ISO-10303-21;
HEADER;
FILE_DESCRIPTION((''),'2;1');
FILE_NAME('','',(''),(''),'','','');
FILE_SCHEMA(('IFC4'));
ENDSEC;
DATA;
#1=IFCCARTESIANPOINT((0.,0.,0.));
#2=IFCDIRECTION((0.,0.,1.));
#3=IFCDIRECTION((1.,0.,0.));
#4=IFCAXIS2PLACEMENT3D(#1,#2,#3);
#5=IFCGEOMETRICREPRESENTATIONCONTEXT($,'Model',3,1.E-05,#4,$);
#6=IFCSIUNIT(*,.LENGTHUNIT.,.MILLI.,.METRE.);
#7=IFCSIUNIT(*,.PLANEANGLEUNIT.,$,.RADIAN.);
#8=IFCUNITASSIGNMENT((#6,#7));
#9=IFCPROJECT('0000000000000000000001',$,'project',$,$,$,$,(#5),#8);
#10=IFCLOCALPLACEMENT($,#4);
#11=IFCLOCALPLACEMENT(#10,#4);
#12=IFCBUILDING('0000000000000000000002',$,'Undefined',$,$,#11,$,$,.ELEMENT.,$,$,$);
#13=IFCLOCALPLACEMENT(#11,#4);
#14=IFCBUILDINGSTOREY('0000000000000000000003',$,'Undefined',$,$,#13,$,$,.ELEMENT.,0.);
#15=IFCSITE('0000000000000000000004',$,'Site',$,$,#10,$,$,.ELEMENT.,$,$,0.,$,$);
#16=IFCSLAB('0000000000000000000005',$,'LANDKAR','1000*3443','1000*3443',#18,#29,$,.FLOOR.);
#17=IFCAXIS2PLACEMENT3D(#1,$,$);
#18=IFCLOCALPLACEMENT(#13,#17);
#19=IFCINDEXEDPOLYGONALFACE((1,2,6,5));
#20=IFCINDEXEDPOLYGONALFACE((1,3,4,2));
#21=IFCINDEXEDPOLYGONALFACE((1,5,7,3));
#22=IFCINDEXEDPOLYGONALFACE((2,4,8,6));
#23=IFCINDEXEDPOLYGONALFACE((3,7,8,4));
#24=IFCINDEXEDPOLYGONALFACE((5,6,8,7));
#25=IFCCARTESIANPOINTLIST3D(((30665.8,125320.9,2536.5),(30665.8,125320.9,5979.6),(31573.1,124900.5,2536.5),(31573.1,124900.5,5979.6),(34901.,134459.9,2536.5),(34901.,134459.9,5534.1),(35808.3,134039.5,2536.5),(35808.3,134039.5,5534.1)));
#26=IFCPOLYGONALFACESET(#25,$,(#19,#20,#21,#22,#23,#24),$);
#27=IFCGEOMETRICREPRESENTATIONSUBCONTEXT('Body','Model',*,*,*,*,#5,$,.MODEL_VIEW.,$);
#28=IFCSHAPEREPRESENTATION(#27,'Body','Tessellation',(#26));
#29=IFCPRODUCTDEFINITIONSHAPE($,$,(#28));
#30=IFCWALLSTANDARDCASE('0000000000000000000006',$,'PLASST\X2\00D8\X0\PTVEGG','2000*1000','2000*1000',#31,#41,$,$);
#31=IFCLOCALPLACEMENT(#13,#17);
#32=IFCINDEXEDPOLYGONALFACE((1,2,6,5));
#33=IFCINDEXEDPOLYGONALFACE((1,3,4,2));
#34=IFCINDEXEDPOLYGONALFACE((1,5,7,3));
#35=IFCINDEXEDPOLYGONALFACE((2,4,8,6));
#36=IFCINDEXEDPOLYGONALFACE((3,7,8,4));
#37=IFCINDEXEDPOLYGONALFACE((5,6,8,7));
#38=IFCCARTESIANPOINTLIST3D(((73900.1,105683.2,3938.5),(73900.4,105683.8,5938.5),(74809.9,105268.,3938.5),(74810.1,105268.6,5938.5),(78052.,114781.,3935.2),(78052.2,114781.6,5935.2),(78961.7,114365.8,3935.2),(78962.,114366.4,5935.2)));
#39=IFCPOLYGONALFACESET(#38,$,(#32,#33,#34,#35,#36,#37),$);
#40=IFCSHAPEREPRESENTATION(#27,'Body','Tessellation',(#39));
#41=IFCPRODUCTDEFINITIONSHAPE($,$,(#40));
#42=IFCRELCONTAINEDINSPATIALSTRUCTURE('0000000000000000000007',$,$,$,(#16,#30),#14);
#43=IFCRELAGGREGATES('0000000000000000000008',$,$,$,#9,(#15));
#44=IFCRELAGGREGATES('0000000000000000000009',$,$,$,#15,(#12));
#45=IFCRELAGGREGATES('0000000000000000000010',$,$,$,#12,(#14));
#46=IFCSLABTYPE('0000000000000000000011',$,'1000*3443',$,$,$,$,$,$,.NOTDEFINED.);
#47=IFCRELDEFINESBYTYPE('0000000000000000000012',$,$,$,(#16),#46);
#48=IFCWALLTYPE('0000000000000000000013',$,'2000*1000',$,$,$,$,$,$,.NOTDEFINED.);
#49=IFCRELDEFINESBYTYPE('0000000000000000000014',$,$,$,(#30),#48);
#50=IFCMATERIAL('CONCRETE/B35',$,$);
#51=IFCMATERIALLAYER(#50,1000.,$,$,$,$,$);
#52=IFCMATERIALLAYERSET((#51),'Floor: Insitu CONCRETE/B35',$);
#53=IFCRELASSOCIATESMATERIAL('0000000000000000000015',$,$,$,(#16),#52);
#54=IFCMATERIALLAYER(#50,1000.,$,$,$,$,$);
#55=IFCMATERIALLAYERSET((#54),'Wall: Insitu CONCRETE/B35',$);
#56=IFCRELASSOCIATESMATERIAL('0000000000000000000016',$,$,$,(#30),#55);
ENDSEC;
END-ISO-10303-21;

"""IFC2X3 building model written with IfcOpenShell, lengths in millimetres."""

from ifc_helpers import new_model, si_unit, frame, frame_2d, origin_with_axes, place, context, subcontext, project, spatial, polyline, rectangle, outline, extrude, material, layer, layer_set, layer_usage, type_object, element, save


model = new_model("IFC2X3")

# Units and contexts
model_context = context("Model", 3, precision=1e-05, world=origin_with_axes())
body_context = subcontext(model_context, "Body", "Model", "MODEL_VIEW")
ifc_project = project(units=[si_unit("LENGTHUNIT", "METRE", prefix="MILLI"), si_unit("PLANEANGLEUNIT", "RADIAN")], contexts=[model_context])

# Site, building, storey
site_placement = place(None, origin_with_axes())
site = spatial("IfcSite", under=ifc_project, at=site_placement, Name="Site", CompositionType="ELEMENT", RefElevation=0.0)
building_placement = place(site_placement, origin_with_axes())
building = spatial("IfcBuilding", under=site, at=building_placement, Name="Undefined", CompositionType="ELEMENT")
storey_placement = place(building_placement, origin_with_axes())
storey = spatial("IfcBuildingStorey", under=building, at=storey_placement, Name="Undefined", CompositionType="ELEMENT", Elevation=0.0)

# Shared definitions
ifc_material_1 = material(Name="CONCRETE/B35")

# Slab
ifc_layer_1 = layer(ifc_material_1, 1000.0)
ifc_layer_set_1 = layer_set([ifc_layer_1], Name="Floor: Insitu CONCRETE/B35")
ifc_layer_usage_1 = layer_usage(ifc_layer_set_1, "AXIS3", "POSITIVE", -500.0)
slab_type_1 = type_object("IfcSlabType", Name="1000*3443", PredefinedType="NOTDEFINED")
slab_1_placement = place(storey_placement, frame((31119.5, 125110.7, 2536.5), z_axis=(0.907309, -0.420464, 0.0), x_axis=(0.420464, 0.907309, 0.000004)))
element("IfcSlab", 1, at=slab_1_placement, inside=storey, type_object=slab_type_1, material=ifc_layer_usage_1, Name="LANDKAR", Description="1000*3443", ObjectType="1000*3443", PredefinedType="FLOOR", context=body_context, shape_type="SweptSolid", body=[
    extrude(outline(polyline([(0.0, 0.0), (10072.7, 0.0), (10072.7, 2997.6), (0.0, 3443.1), (0.0, 0.0)])), frame((0.0, 0.0, -500.0), z_axis=(0.0, 0.0, 1.0), x_axis=(1.0, 0.0, 0.0)), (0.0, 0.0, 1.0), 1000.0),
])

# Wall
ifc_layer_2 = layer(ifc_material_1, 1000.0)
ifc_layer_set_2 = layer_set([ifc_layer_2], Name="Wall: Insitu CONCRETE/B35")
ifc_layer_usage_2 = layer_usage(ifc_layer_set_2, "AXIS2", "POSITIVE", -500.0)
wall_type = type_object("IfcWallType", Name="2000*1000", PredefinedType="NOTDEFINED")
wall_placement = place(storey_placement, frame((78506.8, 114573.4, 3935.2), z_axis=(0.000135, 0.000296, 1.0), x_axis=(-0.41517, -0.909744, 0.000326)))
element("IfcWallStandardCase", 2, at=wall_placement, inside=storey, type_object=wall_type, material=ifc_layer_usage_2, Name="PLASSTØPTVEGG", Description="2000*1000", ObjectType="2000*1000", context=body_context, shape_type="SweptSolid", body=[
    extrude(rectangle(XDim=10000.4, YDim=1000.0, at=frame_2d((0.0, 5000.2), x_axis=(0.0, -1.0))), frame((0.0, 0.0, 0.0), z_axis=(0.0, 0.0, 1.0), x_axis=(0.0, -1.0, 0.0)), (0.0, 0.0, 1.0), 2000.0),
])

save(model, "model.ifc")
